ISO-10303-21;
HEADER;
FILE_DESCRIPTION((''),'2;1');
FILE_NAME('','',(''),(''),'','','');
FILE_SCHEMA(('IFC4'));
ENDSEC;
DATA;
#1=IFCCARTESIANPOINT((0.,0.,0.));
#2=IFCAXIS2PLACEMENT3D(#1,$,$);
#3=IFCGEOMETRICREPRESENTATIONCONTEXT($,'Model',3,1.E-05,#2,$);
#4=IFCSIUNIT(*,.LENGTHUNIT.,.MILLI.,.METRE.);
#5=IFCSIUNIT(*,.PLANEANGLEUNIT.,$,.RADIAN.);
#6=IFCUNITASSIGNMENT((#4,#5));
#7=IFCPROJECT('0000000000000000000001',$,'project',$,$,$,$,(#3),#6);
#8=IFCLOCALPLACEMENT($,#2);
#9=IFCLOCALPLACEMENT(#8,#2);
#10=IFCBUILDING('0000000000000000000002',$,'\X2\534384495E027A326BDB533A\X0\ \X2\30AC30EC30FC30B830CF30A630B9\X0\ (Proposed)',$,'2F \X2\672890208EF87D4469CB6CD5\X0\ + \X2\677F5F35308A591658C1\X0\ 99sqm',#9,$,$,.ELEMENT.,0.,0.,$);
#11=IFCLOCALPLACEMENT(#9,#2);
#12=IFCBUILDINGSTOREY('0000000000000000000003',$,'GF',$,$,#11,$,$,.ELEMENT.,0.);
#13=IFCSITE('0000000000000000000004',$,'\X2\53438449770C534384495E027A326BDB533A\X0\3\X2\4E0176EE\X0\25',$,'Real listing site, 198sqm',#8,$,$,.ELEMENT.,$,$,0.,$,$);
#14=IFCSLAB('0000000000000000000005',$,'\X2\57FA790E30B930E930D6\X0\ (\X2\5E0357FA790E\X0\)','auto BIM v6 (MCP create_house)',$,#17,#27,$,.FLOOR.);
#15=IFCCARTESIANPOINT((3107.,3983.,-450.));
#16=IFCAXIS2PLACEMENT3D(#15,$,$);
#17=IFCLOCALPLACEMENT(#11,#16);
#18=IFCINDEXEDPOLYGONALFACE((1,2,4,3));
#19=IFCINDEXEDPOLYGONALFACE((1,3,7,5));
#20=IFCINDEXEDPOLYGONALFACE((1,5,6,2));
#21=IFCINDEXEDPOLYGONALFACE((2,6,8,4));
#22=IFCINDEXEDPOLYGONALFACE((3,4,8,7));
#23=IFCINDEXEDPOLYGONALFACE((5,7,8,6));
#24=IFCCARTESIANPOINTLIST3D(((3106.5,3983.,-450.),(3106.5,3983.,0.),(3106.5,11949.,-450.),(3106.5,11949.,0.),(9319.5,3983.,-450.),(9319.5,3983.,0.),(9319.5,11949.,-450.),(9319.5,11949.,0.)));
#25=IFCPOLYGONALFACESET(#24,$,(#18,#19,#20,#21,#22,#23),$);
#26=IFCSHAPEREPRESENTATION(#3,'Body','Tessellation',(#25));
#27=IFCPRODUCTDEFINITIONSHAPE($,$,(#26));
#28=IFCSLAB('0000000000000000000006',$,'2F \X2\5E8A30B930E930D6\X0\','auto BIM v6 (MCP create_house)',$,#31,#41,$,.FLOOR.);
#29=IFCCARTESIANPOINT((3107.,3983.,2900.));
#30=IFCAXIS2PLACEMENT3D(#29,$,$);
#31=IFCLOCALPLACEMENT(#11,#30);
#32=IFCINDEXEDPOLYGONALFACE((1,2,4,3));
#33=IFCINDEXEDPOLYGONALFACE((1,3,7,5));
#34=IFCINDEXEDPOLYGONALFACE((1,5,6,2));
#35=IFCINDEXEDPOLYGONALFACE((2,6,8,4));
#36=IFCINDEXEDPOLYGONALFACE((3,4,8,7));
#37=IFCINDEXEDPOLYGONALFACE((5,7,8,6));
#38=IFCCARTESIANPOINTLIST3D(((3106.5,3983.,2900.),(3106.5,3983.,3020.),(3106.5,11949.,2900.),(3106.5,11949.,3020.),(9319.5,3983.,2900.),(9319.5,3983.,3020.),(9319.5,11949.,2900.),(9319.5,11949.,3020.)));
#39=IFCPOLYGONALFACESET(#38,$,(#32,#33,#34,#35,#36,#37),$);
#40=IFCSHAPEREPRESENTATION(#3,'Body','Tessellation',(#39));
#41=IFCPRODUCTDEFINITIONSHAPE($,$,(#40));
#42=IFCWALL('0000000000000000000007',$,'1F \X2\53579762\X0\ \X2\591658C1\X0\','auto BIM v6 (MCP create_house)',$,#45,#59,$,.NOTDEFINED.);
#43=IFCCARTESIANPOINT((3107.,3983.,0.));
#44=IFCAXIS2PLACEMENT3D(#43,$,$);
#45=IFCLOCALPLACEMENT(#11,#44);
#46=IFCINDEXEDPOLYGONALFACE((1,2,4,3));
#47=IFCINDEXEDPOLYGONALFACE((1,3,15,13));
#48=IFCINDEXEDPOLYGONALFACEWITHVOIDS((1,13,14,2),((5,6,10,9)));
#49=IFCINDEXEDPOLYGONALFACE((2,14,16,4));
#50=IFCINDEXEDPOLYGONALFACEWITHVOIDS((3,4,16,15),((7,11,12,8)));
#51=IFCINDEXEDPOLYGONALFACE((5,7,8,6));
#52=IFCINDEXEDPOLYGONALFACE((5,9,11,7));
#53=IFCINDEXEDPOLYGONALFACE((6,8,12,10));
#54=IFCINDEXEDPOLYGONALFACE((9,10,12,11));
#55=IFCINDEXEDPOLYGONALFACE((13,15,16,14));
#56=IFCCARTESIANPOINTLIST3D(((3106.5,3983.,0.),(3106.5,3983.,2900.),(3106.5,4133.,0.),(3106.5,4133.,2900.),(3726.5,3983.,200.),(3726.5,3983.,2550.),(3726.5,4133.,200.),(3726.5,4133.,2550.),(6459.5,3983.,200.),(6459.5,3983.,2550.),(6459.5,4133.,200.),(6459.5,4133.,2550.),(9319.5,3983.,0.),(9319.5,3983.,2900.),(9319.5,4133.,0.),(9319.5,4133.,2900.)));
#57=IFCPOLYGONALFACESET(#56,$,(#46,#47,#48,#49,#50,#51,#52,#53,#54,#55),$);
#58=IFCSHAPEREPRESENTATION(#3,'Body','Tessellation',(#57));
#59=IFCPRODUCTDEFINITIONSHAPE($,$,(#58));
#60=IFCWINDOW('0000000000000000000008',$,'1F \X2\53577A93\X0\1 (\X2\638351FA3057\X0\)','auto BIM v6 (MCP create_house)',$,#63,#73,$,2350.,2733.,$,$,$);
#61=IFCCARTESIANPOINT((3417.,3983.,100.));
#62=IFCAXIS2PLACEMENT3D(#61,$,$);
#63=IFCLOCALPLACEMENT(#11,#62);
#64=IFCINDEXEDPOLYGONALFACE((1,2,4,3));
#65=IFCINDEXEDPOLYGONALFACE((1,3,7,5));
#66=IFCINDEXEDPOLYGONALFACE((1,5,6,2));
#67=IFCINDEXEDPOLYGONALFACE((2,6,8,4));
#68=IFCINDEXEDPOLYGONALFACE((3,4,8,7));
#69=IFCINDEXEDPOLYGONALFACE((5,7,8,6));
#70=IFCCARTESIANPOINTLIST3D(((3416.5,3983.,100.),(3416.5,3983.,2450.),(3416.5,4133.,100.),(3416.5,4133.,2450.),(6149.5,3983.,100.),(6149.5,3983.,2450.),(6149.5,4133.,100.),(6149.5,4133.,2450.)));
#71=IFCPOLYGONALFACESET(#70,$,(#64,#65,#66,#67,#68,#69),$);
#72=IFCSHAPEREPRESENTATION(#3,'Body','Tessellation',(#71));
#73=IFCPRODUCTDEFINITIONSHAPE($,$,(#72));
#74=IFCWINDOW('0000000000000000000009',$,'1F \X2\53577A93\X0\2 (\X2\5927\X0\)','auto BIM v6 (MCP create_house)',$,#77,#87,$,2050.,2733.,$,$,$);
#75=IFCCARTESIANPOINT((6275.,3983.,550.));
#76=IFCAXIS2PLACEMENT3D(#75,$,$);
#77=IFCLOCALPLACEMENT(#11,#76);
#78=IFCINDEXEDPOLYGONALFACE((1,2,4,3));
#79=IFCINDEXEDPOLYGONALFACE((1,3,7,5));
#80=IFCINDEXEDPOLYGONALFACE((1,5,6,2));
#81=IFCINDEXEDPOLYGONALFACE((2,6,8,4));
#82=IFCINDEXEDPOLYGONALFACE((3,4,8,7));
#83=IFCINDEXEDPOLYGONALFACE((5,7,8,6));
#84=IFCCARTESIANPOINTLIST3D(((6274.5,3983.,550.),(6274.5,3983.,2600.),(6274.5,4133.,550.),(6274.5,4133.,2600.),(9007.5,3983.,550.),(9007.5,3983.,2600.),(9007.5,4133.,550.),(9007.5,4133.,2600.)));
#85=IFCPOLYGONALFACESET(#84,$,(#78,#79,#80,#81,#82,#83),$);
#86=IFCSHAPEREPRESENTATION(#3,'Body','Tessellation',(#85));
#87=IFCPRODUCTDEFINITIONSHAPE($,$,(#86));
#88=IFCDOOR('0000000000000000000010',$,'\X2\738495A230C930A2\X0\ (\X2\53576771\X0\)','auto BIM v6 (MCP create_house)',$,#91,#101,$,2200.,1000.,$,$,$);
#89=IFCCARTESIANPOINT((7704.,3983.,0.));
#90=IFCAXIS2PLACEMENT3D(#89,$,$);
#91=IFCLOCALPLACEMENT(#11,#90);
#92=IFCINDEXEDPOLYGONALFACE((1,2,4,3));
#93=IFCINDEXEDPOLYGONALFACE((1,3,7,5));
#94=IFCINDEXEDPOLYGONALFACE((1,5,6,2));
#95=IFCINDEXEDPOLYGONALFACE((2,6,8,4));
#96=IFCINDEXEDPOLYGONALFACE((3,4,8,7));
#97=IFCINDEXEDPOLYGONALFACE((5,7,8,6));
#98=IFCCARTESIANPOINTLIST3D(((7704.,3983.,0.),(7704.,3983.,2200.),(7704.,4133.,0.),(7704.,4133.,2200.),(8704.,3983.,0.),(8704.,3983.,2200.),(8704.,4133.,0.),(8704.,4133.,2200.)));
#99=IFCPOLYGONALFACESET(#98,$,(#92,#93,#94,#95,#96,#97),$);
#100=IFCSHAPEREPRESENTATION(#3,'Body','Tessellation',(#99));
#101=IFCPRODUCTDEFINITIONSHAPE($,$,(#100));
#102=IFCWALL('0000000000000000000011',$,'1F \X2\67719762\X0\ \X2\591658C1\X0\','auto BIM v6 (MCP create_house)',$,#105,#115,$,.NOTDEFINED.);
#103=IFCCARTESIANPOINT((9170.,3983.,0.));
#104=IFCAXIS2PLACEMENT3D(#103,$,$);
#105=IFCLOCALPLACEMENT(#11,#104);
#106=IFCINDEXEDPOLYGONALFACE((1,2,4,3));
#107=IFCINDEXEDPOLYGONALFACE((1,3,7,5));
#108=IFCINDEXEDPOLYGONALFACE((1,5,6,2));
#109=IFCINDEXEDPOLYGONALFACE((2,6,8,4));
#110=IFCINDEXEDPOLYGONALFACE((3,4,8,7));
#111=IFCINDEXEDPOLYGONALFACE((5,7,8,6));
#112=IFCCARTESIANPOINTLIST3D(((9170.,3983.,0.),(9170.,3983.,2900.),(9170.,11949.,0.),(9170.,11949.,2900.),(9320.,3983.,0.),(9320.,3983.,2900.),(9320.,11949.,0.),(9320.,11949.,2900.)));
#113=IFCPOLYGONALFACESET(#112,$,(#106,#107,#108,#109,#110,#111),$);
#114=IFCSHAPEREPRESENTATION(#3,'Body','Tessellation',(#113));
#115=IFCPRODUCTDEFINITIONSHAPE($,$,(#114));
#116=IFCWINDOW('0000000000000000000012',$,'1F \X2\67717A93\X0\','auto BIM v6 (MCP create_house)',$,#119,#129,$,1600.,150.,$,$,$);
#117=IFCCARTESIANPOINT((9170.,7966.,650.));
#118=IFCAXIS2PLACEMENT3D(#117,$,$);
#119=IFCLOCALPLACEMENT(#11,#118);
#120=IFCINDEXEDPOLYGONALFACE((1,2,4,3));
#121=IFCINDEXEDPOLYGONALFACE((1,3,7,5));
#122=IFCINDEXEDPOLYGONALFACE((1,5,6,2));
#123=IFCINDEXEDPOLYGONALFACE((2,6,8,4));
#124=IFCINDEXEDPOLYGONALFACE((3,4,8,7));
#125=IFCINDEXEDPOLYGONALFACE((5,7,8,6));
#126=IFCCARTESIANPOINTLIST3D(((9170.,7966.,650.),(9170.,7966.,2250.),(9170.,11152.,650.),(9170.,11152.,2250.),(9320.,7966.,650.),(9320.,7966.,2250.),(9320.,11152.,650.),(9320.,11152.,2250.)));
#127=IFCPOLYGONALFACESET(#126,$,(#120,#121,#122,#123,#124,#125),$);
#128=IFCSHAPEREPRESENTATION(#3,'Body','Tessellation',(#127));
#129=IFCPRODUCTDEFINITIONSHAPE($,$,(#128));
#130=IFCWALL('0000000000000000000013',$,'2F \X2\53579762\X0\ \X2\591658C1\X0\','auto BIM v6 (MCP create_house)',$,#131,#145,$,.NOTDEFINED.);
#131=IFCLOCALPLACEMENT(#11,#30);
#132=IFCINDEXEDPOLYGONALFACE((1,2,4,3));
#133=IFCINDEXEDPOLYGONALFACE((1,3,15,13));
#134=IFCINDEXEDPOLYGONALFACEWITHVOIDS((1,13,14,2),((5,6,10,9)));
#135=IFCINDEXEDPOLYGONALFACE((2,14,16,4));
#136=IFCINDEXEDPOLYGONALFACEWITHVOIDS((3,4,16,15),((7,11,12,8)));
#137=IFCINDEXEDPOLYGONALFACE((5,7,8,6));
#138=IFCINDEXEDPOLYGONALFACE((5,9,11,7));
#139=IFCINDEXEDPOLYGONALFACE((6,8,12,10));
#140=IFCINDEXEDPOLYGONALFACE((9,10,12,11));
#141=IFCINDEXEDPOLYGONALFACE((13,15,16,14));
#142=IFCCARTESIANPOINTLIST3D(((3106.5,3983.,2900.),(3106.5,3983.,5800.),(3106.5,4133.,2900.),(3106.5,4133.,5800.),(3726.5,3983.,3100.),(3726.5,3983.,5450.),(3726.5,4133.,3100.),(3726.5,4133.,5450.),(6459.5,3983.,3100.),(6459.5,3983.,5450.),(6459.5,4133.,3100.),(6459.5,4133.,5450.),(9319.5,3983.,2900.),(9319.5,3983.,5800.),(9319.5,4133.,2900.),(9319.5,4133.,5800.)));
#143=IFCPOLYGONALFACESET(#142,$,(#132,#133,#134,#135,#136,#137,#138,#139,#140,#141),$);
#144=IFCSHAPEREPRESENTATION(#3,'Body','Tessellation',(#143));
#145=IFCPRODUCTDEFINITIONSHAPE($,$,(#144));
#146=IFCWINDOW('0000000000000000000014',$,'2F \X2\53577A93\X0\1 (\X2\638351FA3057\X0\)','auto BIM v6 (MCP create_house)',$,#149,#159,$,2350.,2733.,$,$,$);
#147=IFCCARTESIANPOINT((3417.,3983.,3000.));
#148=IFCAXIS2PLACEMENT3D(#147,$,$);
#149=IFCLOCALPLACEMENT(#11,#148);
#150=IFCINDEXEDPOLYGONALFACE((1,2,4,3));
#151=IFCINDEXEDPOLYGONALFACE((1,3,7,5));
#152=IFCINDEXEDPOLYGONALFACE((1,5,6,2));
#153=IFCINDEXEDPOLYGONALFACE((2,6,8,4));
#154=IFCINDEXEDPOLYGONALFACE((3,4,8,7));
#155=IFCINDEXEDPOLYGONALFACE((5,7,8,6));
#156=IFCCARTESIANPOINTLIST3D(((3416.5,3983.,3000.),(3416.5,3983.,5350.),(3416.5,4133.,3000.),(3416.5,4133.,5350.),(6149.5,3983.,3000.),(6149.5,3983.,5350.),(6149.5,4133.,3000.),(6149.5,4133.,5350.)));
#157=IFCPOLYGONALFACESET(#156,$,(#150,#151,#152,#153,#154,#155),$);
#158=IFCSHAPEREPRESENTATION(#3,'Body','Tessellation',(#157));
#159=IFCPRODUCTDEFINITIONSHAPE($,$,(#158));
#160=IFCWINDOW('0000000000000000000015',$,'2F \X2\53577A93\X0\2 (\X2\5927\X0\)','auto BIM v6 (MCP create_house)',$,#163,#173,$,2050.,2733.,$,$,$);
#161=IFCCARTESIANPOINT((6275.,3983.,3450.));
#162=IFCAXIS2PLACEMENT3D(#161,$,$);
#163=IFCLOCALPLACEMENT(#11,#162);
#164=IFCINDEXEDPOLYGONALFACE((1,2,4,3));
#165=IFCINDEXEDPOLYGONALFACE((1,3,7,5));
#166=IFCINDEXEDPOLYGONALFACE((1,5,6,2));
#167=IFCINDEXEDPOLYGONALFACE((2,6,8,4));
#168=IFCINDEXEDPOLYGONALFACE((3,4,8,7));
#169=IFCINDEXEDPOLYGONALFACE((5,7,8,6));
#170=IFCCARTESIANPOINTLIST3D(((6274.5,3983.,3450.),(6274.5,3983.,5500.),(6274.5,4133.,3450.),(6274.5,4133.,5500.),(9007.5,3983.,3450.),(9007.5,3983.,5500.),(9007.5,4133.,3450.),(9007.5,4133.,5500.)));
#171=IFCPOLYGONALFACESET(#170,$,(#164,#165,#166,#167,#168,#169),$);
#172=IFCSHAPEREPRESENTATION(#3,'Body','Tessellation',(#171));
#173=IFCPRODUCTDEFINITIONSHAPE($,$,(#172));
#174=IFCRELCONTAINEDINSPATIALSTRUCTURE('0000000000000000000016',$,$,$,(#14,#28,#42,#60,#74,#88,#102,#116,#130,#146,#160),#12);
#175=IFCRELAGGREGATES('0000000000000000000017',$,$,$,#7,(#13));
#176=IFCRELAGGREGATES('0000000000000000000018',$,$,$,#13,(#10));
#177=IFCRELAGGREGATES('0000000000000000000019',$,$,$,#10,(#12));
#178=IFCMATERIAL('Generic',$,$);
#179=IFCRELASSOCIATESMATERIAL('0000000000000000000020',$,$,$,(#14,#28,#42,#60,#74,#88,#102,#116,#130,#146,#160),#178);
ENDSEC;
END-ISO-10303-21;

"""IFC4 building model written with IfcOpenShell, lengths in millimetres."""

from ifc_helpers import new_model, si_unit, frame, frame_2d, origin, place, context, project, spatial, rectangle, extrude, material, element, fill, save


model = new_model("IFC4")

# Units and contexts
model_context = context("Model", 3, precision=1e-05, world=origin())
ifc_project = project(units=[si_unit("LENGTHUNIT", "METRE", prefix="MILLI"), si_unit("PLANEANGLEUNIT", "RADIAN")], contexts=[model_context])

# Site, building, storey
site_placement = place(None, origin())
site = spatial("IfcSite", under=ifc_project, at=site_placement, Name="千葉県千葉市稲毛区3丁目25", ObjectType="Real listing site, 198sqm", CompositionType="ELEMENT", RefElevation=0.0)
building_placement = place(site_placement, origin())
building = spatial("IfcBuilding", under=site, at=building_placement, Name="千葉市稲毛区 ガレージハウス (Proposed)", ObjectType="2F 木造軸組構法 + 板張り外壁 99sqm", CompositionType="ELEMENT", ElevationOfRefHeight=0.0, ElevationOfTerrain=0.0)
storey_placement = place(building_placement, origin())
storey = spatial("IfcBuildingStorey", under=building, at=storey_placement, Name="GF", CompositionType="ELEMENT", Elevation=0.0)

# Slabs
ifc_material = material(Name="Generic")
slab_1_placement = place(storey_placement, frame((3107.0, 3983.0, -450.0)))
element("IfcSlab", 1, at=slab_1_placement, inside=storey, material=ifc_material, Name="基礎スラブ (布基礎)", Description="auto BIM v6 (MCP create_house)", PredefinedType="FLOOR", context=model_context, shape_type="SweptSolid", body=[
    extrude(rectangle(XDim=6213.0, YDim=7966.0, at=frame_2d((3106.0, 3983.0))), frame((3107.0, 3983.0, -450.0)), (0.0, 0.0, 1.0), 450.0),
])
slab_2_placement = place(storey_placement, frame((3107.0, 3983.0, 2900.0)))
element("IfcSlab", 2, at=slab_2_placement, inside=storey, material=ifc_material, Name="2F 床スラブ", Description="auto BIM v6 (MCP create_house)", PredefinedType="FLOOR", context=model_context, shape_type="SweptSolid", body=[
    extrude(rectangle(XDim=6213.0, YDim=7966.0, at=frame_2d((3106.0, 3983.0))), frame((3107.0, 3983.0, 2900.0)), (0.0, 0.0, 1.0), 120.0),
])

# Wall, openings, windows, door
wall_1_placement = place(storey_placement, frame((3107.0, 3983.0, 0.0)))
wall_1 = element("IfcWall", 3, at=wall_1_placement, inside=storey, material=ifc_material, Name="1F 南面 外壁", Description="auto BIM v6 (MCP create_house)", PredefinedType="NOTDEFINED", context=model_context, shape_type="SweptSolid", body=[
    extrude(rectangle(XDim=6213.0, YDim=150.0, at=frame_2d((3106.0, 75.0))), frame((3107.0, 3983.0, 0.0)), (0.0, 0.0, 1.0), 2900.0),
])
opening_1_placement = place(storey_placement, frame((3417.0, 3983.0, 100.0)))
opening_1 = element("IfcOpeningElement", 4, at=opening_1_placement, cuts=wall_1, PredefinedType="NOTDEFINED", context=model_context, shape_type="SweptSolid", body=[
    extrude(rectangle(XDim=2733.0, YDim=150.0, at=frame_2d((1366.0, 75.0))), frame((3417.0, 3983.0, 100.0)), (0.0, 0.0, 1.0), 2350.0),
])
opening_2_placement = place(storey_placement, frame((6275.0, 3983.0, 550.0)))
opening_2 = element("IfcOpeningElement", 5, at=opening_2_placement, cuts=wall_1, PredefinedType="NOTDEFINED", context=model_context, shape_type="SweptSolid", body=[
    extrude(rectangle(XDim=2733.0, YDim=150.0, at=frame_2d((1366.0, 75.0))), frame((6275.0, 3983.0, 550.0)), (0.0, 0.0, 1.0), 2050.0),
])
opening_3_placement = place(storey_placement, frame((7704.0, 3983.0, 0.0)))
opening_3 = element("IfcOpeningElement", 6, at=opening_3_placement, cuts=wall_1, PredefinedType="NOTDEFINED", context=model_context, shape_type="SweptSolid", body=[
    extrude(rectangle(XDim=1000.0, YDim=150.0, at=frame_2d((500.0, 75.0))), frame((7704.0, 3983.0, 0.0)), (0.0, 0.0, 1.0), 2200.0),
])
window_1_placement = place(storey_placement, frame((3417.0, 3983.0, 100.0)))
window_1 = element("IfcWindow", 7, at=window_1_placement, inside=storey, material=ifc_material, Name="1F 南窓1 (掃出し)", Description="auto BIM v6 (MCP create_house)", OverallHeight=2350.0, OverallWidth=2733.0, context=model_context, shape_type="SweptSolid", body=[
    extrude(rectangle(XDim=2733.0, YDim=150.0, at=frame_2d((1366.0, 75.0))), frame((3417.0, 3983.0, 100.0)), (0.0, 0.0, 1.0), 2350.0),
])
fill(opening_1, window_1)
window_2_placement = place(storey_placement, frame((6275.0, 3983.0, 550.0)))
window_2 = element("IfcWindow", 8, at=window_2_placement, inside=storey, material=ifc_material, Name="1F 南窓2 (大)", Description="auto BIM v6 (MCP create_house)", OverallHeight=2050.0, OverallWidth=2733.0, context=model_context, shape_type="SweptSolid", body=[
    extrude(rectangle(XDim=2733.0, YDim=150.0, at=frame_2d((1366.0, 75.0))), frame((6275.0, 3983.0, 550.0)), (0.0, 0.0, 1.0), 2050.0),
])
fill(opening_2, window_2)
door_placement = place(storey_placement, frame((7704.0, 3983.0, 0.0)))
door = element("IfcDoor", 9, at=door_placement, inside=storey, material=ifc_material, Name="玄関ドア (南東)", Description="auto BIM v6 (MCP create_house)", OverallHeight=2200.0, OverallWidth=1000.0, context=model_context, shape_type="SweptSolid", body=[
    extrude(rectangle(XDim=1000.0, YDim=150.0, at=frame_2d((500.0, 75.0))), frame((7704.0, 3983.0, 0.0)), (0.0, 0.0, 1.0), 2200.0),
])
fill(opening_3, door)

# Wall, opening, window
wall_2_placement = place(storey_placement, frame((9170.0, 3983.0, 0.0)))
wall_2 = element("IfcWall", 10, at=wall_2_placement, inside=storey, material=ifc_material, Name="1F 東面 外壁", Description="auto BIM v6 (MCP create_house)", PredefinedType="NOTDEFINED", context=model_context, shape_type="SweptSolid", body=[
    extrude(rectangle(XDim=150.0, YDim=7966.0, at=frame_2d((75.0, 3983.0))), frame((9170.0, 3983.0, 0.0)), (0.0, 0.0, 1.0), 2900.0),
])
opening_4_placement = place(storey_placement, frame((9170.0, 7966.0, 650.0)))
opening_4 = element("IfcOpeningElement", 11, at=opening_4_placement, cuts=wall_2, PredefinedType="NOTDEFINED", context=model_context, shape_type="SweptSolid", body=[
    extrude(rectangle(XDim=150.0, YDim=3186.0, at=frame_2d((75.0, 1593.0))), frame((9170.0, 7966.0, 650.0)), (0.0, 0.0, 1.0), 1600.0),
])
window_3_placement = place(storey_placement, frame((9170.0, 7966.0, 650.0)))
window_3 = element("IfcWindow", 12, at=window_3_placement, inside=storey, material=ifc_material, Name="1F 東窓", Description="auto BIM v6 (MCP create_house)", OverallHeight=1600.0, OverallWidth=150.0, context=model_context, shape_type="SweptSolid", body=[
    extrude(rectangle(XDim=150.0, YDim=3186.0, at=frame_2d((75.0, 1593.0))), frame((9170.0, 7966.0, 650.0)), (0.0, 0.0, 1.0), 1600.0),
])
fill(opening_4, window_3)

# Wall, openings, windows
wall_3_placement = place(storey_placement, frame((3107.0, 3983.0, 2900.0)))
wall_3 = element("IfcWall", 13, at=wall_3_placement, inside=storey, material=ifc_material, Name="2F 南面 外壁", Description="auto BIM v6 (MCP create_house)", PredefinedType="NOTDEFINED", context=model_context, shape_type="SweptSolid", body=[
    extrude(rectangle(XDim=6213.0, YDim=150.0, at=frame_2d((3106.0, 75.0))), frame((3107.0, 3983.0, 2900.0)), (0.0, 0.0, 1.0), 2900.0),
])
opening_5_placement = place(storey_placement, frame((3417.0, 3983.0, 3000.0)))
opening_5 = element("IfcOpeningElement", 14, at=opening_5_placement, cuts=wall_3, PredefinedType="NOTDEFINED", context=model_context, shape_type="SweptSolid", body=[
    extrude(rectangle(XDim=2733.0, YDim=150.0, at=frame_2d((1366.0, 75.0))), frame((3417.0, 3983.0, 3000.0)), (0.0, 0.0, 1.0), 2350.0),
])
opening_6_placement = place(storey_placement, frame((6275.0, 3983.0, 3450.0)))
opening_6 = element("IfcOpeningElement", 15, at=opening_6_placement, cuts=wall_3, PredefinedType="NOTDEFINED", context=model_context, shape_type="SweptSolid", body=[
    extrude(rectangle(XDim=2733.0, YDim=150.0, at=frame_2d((1366.0, 75.0))), frame((6275.0, 3983.0, 3450.0)), (0.0, 0.0, 1.0), 2050.0),
])
window_4_placement = place(storey_placement, frame((3417.0, 3983.0, 3000.0)))
window_4 = element("IfcWindow", 16, at=window_4_placement, inside=storey, material=ifc_material, Name="2F 南窓1 (掃出し)", Description="auto BIM v6 (MCP create_house)", OverallHeight=2350.0, OverallWidth=2733.0, context=model_context, shape_type="SweptSolid", body=[
    extrude(rectangle(XDim=2733.0, YDim=150.0, at=frame_2d((1366.0, 75.0))), frame((3417.0, 3983.0, 3000.0)), (0.0, 0.0, 1.0), 2350.0),
])
fill(opening_5, window_4)
window_5_placement = place(storey_placement, frame((6275.0, 3983.0, 3450.0)))
window_5 = element("IfcWindow", 17, at=window_5_placement, inside=storey, material=ifc_material, Name="2F 南窓2 (大)", Description="auto BIM v6 (MCP create_house)", OverallHeight=2050.0, OverallWidth=2733.0, context=model_context, shape_type="SweptSolid", body=[
    extrude(rectangle(XDim=2733.0, YDim=150.0, at=frame_2d((1366.0, 75.0))), frame((6275.0, 3983.0, 3450.0)), (0.0, 0.0, 1.0), 2050.0),
])
fill(opening_6, window_5)

save(model, "model.ifc")
